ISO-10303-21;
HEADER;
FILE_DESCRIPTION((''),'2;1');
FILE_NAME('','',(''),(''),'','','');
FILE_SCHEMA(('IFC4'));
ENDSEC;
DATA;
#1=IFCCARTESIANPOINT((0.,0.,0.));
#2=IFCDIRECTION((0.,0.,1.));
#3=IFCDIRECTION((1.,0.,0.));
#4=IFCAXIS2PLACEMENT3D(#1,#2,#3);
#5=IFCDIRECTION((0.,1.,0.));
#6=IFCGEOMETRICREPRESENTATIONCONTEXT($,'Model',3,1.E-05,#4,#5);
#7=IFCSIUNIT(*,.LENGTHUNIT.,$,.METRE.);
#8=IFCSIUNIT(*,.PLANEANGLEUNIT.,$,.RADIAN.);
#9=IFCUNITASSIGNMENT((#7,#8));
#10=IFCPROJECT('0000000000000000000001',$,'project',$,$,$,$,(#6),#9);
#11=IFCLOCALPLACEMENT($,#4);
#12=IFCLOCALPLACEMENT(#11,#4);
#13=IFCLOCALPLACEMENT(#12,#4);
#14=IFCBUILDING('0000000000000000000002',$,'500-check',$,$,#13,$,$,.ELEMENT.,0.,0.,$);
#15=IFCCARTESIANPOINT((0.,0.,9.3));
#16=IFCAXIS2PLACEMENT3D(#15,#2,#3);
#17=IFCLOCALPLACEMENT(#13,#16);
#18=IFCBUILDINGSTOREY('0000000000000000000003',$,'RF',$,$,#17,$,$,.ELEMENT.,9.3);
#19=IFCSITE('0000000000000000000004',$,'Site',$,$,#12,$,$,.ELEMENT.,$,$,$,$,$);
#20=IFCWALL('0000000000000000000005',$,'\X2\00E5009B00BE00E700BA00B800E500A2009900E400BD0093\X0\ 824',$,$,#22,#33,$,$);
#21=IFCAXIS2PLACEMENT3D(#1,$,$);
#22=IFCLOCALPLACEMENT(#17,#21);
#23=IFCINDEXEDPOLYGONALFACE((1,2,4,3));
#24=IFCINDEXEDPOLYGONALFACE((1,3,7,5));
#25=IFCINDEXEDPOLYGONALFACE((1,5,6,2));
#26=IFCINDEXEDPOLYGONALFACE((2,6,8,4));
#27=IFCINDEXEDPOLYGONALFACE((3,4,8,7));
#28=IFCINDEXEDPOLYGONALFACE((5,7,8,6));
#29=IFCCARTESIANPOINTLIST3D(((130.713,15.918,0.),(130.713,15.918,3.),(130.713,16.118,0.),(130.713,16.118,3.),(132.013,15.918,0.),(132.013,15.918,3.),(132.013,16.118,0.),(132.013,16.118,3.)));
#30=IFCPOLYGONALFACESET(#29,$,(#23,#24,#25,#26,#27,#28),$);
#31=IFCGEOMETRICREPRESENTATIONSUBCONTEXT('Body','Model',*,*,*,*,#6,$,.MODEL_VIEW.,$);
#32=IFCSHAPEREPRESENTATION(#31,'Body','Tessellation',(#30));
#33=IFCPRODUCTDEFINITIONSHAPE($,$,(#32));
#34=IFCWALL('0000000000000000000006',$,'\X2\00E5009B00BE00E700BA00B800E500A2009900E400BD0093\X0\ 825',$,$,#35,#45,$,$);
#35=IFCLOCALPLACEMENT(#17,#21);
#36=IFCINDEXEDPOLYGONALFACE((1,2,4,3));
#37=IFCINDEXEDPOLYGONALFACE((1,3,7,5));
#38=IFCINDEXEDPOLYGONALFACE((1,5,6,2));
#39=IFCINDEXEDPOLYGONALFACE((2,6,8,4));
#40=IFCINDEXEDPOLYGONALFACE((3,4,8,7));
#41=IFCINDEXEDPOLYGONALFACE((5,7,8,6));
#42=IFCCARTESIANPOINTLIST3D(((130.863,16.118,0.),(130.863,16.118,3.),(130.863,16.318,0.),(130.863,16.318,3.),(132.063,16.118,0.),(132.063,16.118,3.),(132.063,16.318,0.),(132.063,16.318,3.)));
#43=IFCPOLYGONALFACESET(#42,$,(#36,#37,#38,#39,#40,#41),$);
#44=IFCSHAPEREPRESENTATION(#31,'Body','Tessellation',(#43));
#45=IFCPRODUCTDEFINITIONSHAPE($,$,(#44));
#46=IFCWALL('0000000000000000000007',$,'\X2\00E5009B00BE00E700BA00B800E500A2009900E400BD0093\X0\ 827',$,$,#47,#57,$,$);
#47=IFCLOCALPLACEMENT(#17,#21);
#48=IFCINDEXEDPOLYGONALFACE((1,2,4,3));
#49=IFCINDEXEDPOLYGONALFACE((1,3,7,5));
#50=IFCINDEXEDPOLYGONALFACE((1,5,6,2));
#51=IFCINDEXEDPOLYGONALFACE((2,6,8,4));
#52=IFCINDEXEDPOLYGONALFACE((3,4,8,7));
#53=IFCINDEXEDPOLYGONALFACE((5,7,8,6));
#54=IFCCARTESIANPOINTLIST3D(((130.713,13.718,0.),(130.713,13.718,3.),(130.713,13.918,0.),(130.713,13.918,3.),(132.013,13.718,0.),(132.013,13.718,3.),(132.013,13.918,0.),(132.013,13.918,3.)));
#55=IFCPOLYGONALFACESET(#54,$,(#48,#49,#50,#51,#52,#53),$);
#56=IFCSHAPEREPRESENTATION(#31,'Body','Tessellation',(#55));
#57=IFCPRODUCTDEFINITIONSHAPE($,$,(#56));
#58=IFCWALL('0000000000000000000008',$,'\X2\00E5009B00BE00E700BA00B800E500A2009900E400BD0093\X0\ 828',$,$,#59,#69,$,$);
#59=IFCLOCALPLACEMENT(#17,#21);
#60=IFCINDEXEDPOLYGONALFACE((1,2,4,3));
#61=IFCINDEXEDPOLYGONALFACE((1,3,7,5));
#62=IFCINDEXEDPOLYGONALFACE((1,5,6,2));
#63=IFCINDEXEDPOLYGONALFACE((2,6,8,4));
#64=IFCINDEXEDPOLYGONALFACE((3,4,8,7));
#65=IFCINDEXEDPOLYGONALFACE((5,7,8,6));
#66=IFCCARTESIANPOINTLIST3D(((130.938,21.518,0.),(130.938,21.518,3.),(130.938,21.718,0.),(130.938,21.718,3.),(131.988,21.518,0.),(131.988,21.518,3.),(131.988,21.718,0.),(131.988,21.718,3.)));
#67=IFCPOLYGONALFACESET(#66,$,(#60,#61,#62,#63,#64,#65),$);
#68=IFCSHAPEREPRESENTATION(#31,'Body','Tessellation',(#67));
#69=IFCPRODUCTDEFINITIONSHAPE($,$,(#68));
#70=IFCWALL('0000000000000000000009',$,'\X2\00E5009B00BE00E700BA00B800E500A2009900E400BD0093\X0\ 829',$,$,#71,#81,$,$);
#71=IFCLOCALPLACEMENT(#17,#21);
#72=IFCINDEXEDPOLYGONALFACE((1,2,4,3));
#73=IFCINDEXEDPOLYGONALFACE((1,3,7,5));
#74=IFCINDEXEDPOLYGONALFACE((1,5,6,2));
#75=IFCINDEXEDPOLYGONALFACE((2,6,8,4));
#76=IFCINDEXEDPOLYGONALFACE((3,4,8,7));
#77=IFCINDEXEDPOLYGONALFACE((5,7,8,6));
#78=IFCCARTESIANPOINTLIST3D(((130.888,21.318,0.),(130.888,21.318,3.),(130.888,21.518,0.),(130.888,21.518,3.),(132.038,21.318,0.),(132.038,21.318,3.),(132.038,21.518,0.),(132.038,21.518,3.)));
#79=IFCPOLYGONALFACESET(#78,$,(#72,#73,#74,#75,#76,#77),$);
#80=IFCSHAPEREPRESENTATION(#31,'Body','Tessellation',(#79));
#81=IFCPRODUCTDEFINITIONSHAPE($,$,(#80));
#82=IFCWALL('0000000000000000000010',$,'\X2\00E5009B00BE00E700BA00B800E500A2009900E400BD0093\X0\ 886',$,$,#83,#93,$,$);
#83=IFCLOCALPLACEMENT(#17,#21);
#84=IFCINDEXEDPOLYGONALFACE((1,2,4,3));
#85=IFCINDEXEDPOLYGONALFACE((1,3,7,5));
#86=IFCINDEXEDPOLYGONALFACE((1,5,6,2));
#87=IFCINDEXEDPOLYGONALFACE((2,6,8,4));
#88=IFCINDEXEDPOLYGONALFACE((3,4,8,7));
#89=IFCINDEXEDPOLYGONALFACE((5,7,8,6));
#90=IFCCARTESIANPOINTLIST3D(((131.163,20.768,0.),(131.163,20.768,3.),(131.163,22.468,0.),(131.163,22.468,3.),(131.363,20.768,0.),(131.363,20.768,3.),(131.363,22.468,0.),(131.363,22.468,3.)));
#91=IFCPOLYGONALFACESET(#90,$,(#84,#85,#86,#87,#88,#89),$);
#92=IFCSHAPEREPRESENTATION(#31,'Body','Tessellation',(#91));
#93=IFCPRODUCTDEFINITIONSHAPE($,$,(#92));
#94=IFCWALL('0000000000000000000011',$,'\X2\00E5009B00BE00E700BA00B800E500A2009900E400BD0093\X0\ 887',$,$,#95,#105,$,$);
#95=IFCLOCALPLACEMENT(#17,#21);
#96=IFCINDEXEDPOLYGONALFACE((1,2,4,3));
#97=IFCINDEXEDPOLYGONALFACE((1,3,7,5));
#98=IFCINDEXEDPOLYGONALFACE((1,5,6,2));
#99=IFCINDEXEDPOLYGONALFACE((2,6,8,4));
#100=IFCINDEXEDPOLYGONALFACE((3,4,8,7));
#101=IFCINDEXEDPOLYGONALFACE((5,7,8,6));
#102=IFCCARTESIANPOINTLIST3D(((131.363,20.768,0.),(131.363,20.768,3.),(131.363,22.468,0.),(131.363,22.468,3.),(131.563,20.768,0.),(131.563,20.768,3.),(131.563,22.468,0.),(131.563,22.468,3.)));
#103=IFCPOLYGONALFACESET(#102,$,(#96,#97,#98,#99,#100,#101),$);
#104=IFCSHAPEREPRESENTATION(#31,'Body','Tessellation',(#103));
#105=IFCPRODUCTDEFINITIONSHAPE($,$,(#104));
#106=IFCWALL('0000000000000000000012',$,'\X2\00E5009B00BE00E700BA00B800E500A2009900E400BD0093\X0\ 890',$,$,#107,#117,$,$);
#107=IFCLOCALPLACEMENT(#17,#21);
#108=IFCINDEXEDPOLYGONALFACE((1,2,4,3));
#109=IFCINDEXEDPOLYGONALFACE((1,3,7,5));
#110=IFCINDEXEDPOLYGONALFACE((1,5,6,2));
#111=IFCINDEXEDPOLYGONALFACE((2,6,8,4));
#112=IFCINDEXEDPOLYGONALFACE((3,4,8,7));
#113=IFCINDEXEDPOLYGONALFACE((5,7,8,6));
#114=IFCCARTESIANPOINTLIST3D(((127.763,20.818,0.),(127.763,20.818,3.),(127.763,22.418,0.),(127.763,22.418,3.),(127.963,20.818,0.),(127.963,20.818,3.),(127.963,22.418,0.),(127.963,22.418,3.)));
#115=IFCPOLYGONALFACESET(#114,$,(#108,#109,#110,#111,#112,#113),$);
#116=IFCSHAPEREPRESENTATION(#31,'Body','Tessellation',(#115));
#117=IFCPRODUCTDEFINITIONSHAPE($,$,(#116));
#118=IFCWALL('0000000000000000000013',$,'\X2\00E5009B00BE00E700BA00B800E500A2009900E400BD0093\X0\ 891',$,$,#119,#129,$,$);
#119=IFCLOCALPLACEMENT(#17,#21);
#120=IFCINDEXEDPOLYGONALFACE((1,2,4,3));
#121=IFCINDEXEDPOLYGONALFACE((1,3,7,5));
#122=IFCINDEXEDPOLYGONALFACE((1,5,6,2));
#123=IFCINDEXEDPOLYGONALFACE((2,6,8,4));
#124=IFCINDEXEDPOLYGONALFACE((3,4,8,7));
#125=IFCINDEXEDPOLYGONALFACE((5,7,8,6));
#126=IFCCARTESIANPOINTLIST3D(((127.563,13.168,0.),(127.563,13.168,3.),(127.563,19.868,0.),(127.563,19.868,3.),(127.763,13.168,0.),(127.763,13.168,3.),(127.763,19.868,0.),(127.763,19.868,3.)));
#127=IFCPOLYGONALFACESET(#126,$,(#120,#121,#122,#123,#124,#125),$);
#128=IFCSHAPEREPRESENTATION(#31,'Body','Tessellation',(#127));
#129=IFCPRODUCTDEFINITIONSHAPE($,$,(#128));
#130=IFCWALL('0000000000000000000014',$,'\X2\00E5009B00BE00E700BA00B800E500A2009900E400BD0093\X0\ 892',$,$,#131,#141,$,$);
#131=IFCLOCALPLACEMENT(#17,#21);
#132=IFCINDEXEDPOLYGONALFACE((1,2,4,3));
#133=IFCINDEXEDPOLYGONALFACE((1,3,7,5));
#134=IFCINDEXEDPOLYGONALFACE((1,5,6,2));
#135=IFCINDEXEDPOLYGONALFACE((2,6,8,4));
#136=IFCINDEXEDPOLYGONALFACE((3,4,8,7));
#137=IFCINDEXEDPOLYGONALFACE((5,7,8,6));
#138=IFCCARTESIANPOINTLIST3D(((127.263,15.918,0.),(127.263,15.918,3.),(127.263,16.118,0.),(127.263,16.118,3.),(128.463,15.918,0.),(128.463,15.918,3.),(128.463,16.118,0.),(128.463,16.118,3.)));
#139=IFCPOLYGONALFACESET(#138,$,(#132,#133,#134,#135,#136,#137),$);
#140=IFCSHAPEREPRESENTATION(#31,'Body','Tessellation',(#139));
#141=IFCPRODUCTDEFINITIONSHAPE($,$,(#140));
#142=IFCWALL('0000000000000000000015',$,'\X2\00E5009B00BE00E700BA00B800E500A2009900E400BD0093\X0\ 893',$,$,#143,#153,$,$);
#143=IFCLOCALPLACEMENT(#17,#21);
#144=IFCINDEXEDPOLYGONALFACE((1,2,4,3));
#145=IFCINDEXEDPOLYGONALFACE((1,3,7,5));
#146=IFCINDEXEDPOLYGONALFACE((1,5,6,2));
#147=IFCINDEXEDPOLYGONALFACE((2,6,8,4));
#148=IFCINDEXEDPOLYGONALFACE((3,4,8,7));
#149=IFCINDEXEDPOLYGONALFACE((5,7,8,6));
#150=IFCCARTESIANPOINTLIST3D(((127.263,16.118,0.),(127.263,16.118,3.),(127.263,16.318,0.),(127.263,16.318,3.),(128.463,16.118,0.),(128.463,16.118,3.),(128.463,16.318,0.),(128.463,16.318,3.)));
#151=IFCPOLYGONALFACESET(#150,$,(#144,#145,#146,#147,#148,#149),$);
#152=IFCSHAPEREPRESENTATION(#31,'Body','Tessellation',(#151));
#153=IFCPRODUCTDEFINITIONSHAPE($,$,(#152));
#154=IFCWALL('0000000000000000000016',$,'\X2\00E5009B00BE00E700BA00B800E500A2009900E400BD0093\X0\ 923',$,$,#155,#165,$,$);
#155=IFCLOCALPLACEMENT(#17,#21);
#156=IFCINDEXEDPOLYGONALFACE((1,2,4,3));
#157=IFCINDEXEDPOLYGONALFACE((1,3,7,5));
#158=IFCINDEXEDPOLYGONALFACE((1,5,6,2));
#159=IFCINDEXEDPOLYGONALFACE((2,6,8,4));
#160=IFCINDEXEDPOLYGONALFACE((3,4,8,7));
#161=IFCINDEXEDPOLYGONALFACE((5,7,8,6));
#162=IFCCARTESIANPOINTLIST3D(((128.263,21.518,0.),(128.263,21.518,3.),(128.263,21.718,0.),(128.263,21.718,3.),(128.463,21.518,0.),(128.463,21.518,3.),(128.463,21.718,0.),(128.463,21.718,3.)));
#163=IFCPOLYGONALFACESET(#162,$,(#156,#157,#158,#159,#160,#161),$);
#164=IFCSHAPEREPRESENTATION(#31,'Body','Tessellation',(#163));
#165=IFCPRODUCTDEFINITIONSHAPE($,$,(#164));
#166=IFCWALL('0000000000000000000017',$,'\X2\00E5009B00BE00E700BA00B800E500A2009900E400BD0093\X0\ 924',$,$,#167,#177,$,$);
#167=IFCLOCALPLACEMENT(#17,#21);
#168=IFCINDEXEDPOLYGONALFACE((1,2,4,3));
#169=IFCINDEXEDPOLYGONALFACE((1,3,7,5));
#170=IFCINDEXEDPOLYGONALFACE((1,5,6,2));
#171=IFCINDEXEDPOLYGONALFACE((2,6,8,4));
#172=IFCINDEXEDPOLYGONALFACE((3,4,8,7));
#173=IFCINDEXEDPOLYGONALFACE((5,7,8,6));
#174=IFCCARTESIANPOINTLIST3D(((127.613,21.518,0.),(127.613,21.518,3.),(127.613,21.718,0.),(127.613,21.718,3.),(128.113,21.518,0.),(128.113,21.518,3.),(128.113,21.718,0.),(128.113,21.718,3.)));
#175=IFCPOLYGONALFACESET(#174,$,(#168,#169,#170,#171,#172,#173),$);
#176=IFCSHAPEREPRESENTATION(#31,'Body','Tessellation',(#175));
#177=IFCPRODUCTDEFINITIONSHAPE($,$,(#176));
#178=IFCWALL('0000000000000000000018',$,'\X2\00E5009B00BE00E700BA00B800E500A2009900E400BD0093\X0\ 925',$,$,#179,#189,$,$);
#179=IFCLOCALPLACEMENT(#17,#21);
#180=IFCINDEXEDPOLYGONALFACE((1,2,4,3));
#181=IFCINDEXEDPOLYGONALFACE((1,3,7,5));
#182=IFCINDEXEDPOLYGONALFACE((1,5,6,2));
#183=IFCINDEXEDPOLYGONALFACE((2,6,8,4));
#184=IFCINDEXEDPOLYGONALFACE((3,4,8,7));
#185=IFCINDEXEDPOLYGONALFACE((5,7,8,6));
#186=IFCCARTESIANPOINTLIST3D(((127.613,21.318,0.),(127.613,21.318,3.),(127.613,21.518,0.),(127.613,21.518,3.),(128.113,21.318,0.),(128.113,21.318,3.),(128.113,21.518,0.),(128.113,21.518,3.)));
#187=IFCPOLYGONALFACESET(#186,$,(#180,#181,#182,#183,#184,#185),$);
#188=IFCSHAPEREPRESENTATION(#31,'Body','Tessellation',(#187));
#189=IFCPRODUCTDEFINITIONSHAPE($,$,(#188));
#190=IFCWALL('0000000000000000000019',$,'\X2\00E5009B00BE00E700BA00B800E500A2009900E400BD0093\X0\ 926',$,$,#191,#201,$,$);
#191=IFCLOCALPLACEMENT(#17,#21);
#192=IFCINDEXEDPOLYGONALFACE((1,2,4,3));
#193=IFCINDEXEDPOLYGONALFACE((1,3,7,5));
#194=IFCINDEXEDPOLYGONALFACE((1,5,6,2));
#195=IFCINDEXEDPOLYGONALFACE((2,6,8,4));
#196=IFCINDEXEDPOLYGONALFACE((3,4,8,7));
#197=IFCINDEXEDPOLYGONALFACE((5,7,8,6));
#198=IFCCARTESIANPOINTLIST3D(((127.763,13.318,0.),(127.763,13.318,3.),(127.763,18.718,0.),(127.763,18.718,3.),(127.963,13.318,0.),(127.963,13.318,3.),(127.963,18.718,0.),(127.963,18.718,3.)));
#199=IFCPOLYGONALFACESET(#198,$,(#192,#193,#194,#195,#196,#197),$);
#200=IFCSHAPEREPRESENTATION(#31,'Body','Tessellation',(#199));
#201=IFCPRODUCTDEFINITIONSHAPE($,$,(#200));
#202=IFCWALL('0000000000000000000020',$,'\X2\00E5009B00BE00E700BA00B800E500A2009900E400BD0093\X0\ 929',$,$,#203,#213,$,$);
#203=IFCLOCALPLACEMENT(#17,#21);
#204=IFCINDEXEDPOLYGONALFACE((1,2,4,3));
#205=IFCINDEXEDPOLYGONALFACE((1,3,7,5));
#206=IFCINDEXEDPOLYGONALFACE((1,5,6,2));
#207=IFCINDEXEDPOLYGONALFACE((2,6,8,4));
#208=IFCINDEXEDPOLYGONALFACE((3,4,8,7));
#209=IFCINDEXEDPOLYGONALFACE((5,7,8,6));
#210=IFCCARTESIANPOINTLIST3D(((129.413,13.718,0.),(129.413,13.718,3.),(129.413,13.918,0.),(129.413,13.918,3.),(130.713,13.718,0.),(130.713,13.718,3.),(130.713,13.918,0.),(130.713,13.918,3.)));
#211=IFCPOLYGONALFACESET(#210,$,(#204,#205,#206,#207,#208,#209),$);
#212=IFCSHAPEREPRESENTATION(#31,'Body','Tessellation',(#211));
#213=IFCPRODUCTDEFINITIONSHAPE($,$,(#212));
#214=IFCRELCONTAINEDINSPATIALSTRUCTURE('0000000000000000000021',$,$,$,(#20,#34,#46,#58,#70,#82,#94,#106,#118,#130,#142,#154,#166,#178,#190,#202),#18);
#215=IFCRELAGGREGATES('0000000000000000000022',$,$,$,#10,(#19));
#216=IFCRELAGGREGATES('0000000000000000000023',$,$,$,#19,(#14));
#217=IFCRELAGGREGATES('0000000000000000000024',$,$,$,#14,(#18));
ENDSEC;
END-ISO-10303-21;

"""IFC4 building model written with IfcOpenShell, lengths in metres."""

from ifc_helpers import new_model, si_unit, direction, frame, frame_2d, origin_with_axes, place, context, subcontext, project, spatial, rectangle, extrude, element, save


model = new_model("IFC4")

# Units and contexts
model_context = context("Model", 3, precision=1e-05, world=origin_with_axes(), true_north=direction((0.0, 1.0, 0.0)))
body_context = subcontext(model_context, "Body", "Model", "MODEL_VIEW")
ifc_project = project(units=[si_unit("LENGTHUNIT", "METRE"), si_unit("PLANEANGLEUNIT", "RADIAN")], contexts=[model_context])

# Site, building, storey
placement = place(None, origin_with_axes())
site_placement = place(placement, origin_with_axes())
site = spatial("IfcSite", under=ifc_project, at=site_placement, Name="Site", CompositionType="ELEMENT")
building_placement = place(site_placement, origin_with_axes())
building = spatial("IfcBuilding", under=site, at=building_placement, Name="500-check", CompositionType="ELEMENT", ElevationOfRefHeight=0.0, ElevationOfTerrain=0.0)
storey_placement = place(building_placement, frame((0.0, 0.0, 9.3), z_axis=(0.0, 0.0, 1.0), x_axis=(1.0, 0.0, 0.0)))
storey = spatial("IfcBuildingStorey", under=building, at=storey_placement, Name="RF", CompositionType="ELEMENT", Elevation=9.3)

# Walls
wall_1_placement = place(storey_placement, frame((131.363, 16.018, 0.0), z_axis=(0.0, 0.0, 1.0), x_axis=(1.0, 0.0, 0.0)))
element("IfcWall", 1, at=wall_1_placement, inside=storey, Name="å\u009b¾çº¸å¢\u0099ä½\u0093 824", context=body_context, shape_type="SweptSolid", body=[
    extrude(rectangle(XDim=1.3, YDim=0.2, at=frame_2d((0.0, 0.0), x_axis=(1.0, 0.0, 0.0))), frame((0.0, 0.0, 0.0), z_axis=(0.0, 0.0, 1.0)), (0.0, 0.0, 1.0), 3.0),
])
wall_2_placement = place(storey_placement, frame((131.463, 16.218, 0.0), z_axis=(0.0, 0.0, 1.0), x_axis=(1.0, 0.0, 0.0)))
element("IfcWall", 2, at=wall_2_placement, inside=storey, Name="å\u009b¾çº¸å¢\u0099ä½\u0093 825", context=body_context, shape_type="SweptSolid", body=[
    extrude(rectangle(XDim=1.2, YDim=0.2, at=frame_2d((0.0, 0.0), x_axis=(1.0, 0.0, 0.0))), frame((0.0, 0.0, 0.0), z_axis=(0.0, 0.0, 1.0)), (0.0, 0.0, 1.0), 3.0),
])
wall_3_placement = place(storey_placement, frame((131.363, 13.818, 0.0), z_axis=(0.0, 0.0, 1.0), x_axis=(1.0, 0.0, 0.0)))
element("IfcWall", 3, at=wall_3_placement, inside=storey, Name="å\u009b¾çº¸å¢\u0099ä½\u0093 827", context=body_context, shape_type="SweptSolid", body=[
    extrude(rectangle(XDim=1.3, YDim=0.2, at=frame_2d((0.0, 0.0), x_axis=(1.0, 0.0, 0.0))), frame((0.0, 0.0, 0.0), z_axis=(0.0, 0.0, 1.0)), (0.0, 0.0, 1.0), 3.0),
])
wall_4_placement = place(storey_placement, frame((131.463, 21.618, 0.0), z_axis=(0.0, 0.0, 1.0), x_axis=(1.0, 0.0, 0.0)))
element("IfcWall", 4, at=wall_4_placement, inside=storey, Name="å\u009b¾çº¸å¢\u0099ä½\u0093 828", context=body_context, shape_type="SweptSolid", body=[
    extrude(rectangle(XDim=1.05, YDim=0.2, at=frame_2d((0.0, 0.0), x_axis=(1.0, 0.0, 0.0))), frame((0.0, 0.0, 0.0), z_axis=(0.0, 0.0, 1.0)), (0.0, 0.0, 1.0), 3.0),
])
wall_5_placement = place(storey_placement, frame((131.463, 21.418, 0.0), z_axis=(0.0, 0.0, 1.0), x_axis=(1.0, 0.0, 0.0)))
element("IfcWall", 5, at=wall_5_placement, inside=storey, Name="å\u009b¾çº¸å¢\u0099ä½\u0093 829", context=body_context, shape_type="SweptSolid", body=[
    extrude(rectangle(XDim=1.15, YDim=0.2, at=frame_2d((0.0, 0.0), x_axis=(1.0, 0.0, 0.0))), frame((0.0, 0.0, 0.0), z_axis=(0.0, 0.0, 1.0)), (0.0, 0.0, 1.0), 3.0),
])
for number, where, z_axis, x_axis, name in (
    (6, (131.263, 21.618, 0.0), (0.0, 0.0, 1.0), (0.0, 1.0, 0.0), "å\u009b¾çº¸å¢\u0099ä½\u0093 886"),
    (7, (131.463, 21.618, 0.0), (0.0, 0.0, 1.0), (0.0, 1.0, 0.0), "å\u009b¾çº¸å¢\u0099ä½\u0093 887"),
):
    element("IfcWall", number, at=place(storey_placement, frame(where, z_axis=z_axis, x_axis=x_axis)), inside=storey, Name=name, context=body_context, shape_type="SweptSolid", body=[
        extrude(rectangle(XDim=1.7, YDim=0.2, at=frame_2d((0.0, 0.0), x_axis=(1.0, 0.0, 0.0))), frame((0.0, 0.0, 0.0), z_axis=(0.0, 0.0, 1.0)), (0.0, 0.0, 1.0), 3.0),
    ])
wall_6_placement = place(storey_placement, frame((127.863, 21.618, 0.0), z_axis=(0.0, 0.0, 1.0), x_axis=(0.0, 1.0, 0.0)))
element("IfcWall", 8, at=wall_6_placement, inside=storey, Name="å\u009b¾çº¸å¢\u0099ä½\u0093 890", context=body_context, shape_type="SweptSolid", body=[
    extrude(rectangle(XDim=1.6, YDim=0.2, at=frame_2d((0.0, 0.0), x_axis=(1.0, 0.0, 0.0))), frame((0.0, 0.0, 0.0), z_axis=(0.0, 0.0, 1.0)), (0.0, 0.0, 1.0), 3.0),
])
wall_7_placement = place(storey_placement, frame((127.663, 16.518, 0.0), z_axis=(0.0, 0.0, 1.0), x_axis=(0.0, 1.0, 0.0)))
element("IfcWall", 9, at=wall_7_placement, inside=storey, Name="å\u009b¾çº¸å¢\u0099ä½\u0093 891", context=body_context, shape_type="SweptSolid", body=[
    extrude(rectangle(XDim=6.7, YDim=0.2, at=frame_2d((0.0, 0.0), x_axis=(1.0, 0.0, 0.0))), frame((0.0, 0.0, 0.0), z_axis=(0.0, 0.0, 1.0)), (0.0, 0.0, 1.0), 3.0),
])
for number, where, z_axis, x_axis, name in (
    (10, (127.863, 16.018, 0.0), (0.0, 0.0, 1.0), (1.0, 0.0, 0.0), "å\u009b¾çº¸å¢\u0099ä½\u0093 892"),
    (11, (127.863, 16.218, 0.0), (0.0, 0.0, 1.0), (1.0, 0.0, 0.0), "å\u009b¾çº¸å¢\u0099ä½\u0093 893"),
):
    element("IfcWall", number, at=place(storey_placement, frame(where, z_axis=z_axis, x_axis=x_axis)), inside=storey, Name=name, context=body_context, shape_type="SweptSolid", body=[
        extrude(rectangle(XDim=1.2, YDim=0.2, at=frame_2d((0.0, 0.0), x_axis=(1.0, 0.0, 0.0))), frame((0.0, 0.0, 0.0), z_axis=(0.0, 0.0, 1.0)), (0.0, 0.0, 1.0), 3.0),
    ])
wall_8_placement = place(storey_placement, frame((128.363, 21.618, 0.0), z_axis=(0.0, 0.0, 1.0), x_axis=(0.0, -1.0, 0.0)))
element("IfcWall", 12, at=wall_8_placement, inside=storey, Name="å\u009b¾çº¸å¢\u0099ä½\u0093 923", context=body_context, shape_type="SweptSolid", body=[
    extrude(rectangle(XDim=0.2, YDim=0.2, at=frame_2d((0.0, 0.0), x_axis=(1.0, 0.0, 0.0))), frame((0.0, 0.0, 0.0), z_axis=(0.0, 0.0, 1.0)), (0.0, 0.0, 1.0), 3.0),
])
for number, where, z_axis, x_axis, name in (
    (13, (127.863, 21.618, 0.0), (0.0, 0.0, 1.0), (1.0, 0.0, 0.0), "å\u009b¾çº¸å¢\u0099ä½\u0093 924"),
    (14, (127.863, 21.418, 0.0), (0.0, 0.0, 1.0), (1.0, 0.0, 0.0), "å\u009b¾çº¸å¢\u0099ä½\u0093 925"),
):
    element("IfcWall", number, at=place(storey_placement, frame(where, z_axis=z_axis, x_axis=x_axis)), inside=storey, Name=name, context=body_context, shape_type="SweptSolid", body=[
        extrude(rectangle(XDim=0.5, YDim=0.2, at=frame_2d((0.0, 0.0), x_axis=(1.0, 0.0, 0.0))), frame((0.0, 0.0, 0.0), z_axis=(0.0, 0.0, 1.0)), (0.0, 0.0, 1.0), 3.0),
    ])
wall_9_placement = place(storey_placement, frame((127.863, 16.018, 0.0), z_axis=(0.0, 0.0, 1.0), x_axis=(0.0, 1.0, 0.0)))
element("IfcWall", 15, at=wall_9_placement, inside=storey, Name="å\u009b¾çº¸å¢\u0099ä½\u0093 926", context=body_context, shape_type="SweptSolid", body=[
    extrude(rectangle(XDim=5.4, YDim=0.2, at=frame_2d((0.0, 0.0), x_axis=(1.0, 0.0, 0.0))), frame((0.0, 0.0, 0.0), z_axis=(0.0, 0.0, 1.0)), (0.0, 0.0, 1.0), 3.0),
])
wall_10_placement = place(storey_placement, frame((130.063, 13.818, 0.0), z_axis=(0.0, 0.0, 1.0), x_axis=(1.0, 0.0, 0.0)))
element("IfcWall", 16, at=wall_10_placement, inside=storey, Name="å\u009b¾çº¸å¢\u0099ä½\u0093 929", context=body_context, shape_type="SweptSolid", body=[
    extrude(rectangle(XDim=1.3, YDim=0.2, at=frame_2d((0.0, 0.0), x_axis=(1.0, 0.0, 0.0))), frame((0.0, 0.0, 0.0), z_axis=(0.0, 0.0, 1.0)), (0.0, 0.0, 1.0), 3.0),
])

save(model, "model.ifc")
